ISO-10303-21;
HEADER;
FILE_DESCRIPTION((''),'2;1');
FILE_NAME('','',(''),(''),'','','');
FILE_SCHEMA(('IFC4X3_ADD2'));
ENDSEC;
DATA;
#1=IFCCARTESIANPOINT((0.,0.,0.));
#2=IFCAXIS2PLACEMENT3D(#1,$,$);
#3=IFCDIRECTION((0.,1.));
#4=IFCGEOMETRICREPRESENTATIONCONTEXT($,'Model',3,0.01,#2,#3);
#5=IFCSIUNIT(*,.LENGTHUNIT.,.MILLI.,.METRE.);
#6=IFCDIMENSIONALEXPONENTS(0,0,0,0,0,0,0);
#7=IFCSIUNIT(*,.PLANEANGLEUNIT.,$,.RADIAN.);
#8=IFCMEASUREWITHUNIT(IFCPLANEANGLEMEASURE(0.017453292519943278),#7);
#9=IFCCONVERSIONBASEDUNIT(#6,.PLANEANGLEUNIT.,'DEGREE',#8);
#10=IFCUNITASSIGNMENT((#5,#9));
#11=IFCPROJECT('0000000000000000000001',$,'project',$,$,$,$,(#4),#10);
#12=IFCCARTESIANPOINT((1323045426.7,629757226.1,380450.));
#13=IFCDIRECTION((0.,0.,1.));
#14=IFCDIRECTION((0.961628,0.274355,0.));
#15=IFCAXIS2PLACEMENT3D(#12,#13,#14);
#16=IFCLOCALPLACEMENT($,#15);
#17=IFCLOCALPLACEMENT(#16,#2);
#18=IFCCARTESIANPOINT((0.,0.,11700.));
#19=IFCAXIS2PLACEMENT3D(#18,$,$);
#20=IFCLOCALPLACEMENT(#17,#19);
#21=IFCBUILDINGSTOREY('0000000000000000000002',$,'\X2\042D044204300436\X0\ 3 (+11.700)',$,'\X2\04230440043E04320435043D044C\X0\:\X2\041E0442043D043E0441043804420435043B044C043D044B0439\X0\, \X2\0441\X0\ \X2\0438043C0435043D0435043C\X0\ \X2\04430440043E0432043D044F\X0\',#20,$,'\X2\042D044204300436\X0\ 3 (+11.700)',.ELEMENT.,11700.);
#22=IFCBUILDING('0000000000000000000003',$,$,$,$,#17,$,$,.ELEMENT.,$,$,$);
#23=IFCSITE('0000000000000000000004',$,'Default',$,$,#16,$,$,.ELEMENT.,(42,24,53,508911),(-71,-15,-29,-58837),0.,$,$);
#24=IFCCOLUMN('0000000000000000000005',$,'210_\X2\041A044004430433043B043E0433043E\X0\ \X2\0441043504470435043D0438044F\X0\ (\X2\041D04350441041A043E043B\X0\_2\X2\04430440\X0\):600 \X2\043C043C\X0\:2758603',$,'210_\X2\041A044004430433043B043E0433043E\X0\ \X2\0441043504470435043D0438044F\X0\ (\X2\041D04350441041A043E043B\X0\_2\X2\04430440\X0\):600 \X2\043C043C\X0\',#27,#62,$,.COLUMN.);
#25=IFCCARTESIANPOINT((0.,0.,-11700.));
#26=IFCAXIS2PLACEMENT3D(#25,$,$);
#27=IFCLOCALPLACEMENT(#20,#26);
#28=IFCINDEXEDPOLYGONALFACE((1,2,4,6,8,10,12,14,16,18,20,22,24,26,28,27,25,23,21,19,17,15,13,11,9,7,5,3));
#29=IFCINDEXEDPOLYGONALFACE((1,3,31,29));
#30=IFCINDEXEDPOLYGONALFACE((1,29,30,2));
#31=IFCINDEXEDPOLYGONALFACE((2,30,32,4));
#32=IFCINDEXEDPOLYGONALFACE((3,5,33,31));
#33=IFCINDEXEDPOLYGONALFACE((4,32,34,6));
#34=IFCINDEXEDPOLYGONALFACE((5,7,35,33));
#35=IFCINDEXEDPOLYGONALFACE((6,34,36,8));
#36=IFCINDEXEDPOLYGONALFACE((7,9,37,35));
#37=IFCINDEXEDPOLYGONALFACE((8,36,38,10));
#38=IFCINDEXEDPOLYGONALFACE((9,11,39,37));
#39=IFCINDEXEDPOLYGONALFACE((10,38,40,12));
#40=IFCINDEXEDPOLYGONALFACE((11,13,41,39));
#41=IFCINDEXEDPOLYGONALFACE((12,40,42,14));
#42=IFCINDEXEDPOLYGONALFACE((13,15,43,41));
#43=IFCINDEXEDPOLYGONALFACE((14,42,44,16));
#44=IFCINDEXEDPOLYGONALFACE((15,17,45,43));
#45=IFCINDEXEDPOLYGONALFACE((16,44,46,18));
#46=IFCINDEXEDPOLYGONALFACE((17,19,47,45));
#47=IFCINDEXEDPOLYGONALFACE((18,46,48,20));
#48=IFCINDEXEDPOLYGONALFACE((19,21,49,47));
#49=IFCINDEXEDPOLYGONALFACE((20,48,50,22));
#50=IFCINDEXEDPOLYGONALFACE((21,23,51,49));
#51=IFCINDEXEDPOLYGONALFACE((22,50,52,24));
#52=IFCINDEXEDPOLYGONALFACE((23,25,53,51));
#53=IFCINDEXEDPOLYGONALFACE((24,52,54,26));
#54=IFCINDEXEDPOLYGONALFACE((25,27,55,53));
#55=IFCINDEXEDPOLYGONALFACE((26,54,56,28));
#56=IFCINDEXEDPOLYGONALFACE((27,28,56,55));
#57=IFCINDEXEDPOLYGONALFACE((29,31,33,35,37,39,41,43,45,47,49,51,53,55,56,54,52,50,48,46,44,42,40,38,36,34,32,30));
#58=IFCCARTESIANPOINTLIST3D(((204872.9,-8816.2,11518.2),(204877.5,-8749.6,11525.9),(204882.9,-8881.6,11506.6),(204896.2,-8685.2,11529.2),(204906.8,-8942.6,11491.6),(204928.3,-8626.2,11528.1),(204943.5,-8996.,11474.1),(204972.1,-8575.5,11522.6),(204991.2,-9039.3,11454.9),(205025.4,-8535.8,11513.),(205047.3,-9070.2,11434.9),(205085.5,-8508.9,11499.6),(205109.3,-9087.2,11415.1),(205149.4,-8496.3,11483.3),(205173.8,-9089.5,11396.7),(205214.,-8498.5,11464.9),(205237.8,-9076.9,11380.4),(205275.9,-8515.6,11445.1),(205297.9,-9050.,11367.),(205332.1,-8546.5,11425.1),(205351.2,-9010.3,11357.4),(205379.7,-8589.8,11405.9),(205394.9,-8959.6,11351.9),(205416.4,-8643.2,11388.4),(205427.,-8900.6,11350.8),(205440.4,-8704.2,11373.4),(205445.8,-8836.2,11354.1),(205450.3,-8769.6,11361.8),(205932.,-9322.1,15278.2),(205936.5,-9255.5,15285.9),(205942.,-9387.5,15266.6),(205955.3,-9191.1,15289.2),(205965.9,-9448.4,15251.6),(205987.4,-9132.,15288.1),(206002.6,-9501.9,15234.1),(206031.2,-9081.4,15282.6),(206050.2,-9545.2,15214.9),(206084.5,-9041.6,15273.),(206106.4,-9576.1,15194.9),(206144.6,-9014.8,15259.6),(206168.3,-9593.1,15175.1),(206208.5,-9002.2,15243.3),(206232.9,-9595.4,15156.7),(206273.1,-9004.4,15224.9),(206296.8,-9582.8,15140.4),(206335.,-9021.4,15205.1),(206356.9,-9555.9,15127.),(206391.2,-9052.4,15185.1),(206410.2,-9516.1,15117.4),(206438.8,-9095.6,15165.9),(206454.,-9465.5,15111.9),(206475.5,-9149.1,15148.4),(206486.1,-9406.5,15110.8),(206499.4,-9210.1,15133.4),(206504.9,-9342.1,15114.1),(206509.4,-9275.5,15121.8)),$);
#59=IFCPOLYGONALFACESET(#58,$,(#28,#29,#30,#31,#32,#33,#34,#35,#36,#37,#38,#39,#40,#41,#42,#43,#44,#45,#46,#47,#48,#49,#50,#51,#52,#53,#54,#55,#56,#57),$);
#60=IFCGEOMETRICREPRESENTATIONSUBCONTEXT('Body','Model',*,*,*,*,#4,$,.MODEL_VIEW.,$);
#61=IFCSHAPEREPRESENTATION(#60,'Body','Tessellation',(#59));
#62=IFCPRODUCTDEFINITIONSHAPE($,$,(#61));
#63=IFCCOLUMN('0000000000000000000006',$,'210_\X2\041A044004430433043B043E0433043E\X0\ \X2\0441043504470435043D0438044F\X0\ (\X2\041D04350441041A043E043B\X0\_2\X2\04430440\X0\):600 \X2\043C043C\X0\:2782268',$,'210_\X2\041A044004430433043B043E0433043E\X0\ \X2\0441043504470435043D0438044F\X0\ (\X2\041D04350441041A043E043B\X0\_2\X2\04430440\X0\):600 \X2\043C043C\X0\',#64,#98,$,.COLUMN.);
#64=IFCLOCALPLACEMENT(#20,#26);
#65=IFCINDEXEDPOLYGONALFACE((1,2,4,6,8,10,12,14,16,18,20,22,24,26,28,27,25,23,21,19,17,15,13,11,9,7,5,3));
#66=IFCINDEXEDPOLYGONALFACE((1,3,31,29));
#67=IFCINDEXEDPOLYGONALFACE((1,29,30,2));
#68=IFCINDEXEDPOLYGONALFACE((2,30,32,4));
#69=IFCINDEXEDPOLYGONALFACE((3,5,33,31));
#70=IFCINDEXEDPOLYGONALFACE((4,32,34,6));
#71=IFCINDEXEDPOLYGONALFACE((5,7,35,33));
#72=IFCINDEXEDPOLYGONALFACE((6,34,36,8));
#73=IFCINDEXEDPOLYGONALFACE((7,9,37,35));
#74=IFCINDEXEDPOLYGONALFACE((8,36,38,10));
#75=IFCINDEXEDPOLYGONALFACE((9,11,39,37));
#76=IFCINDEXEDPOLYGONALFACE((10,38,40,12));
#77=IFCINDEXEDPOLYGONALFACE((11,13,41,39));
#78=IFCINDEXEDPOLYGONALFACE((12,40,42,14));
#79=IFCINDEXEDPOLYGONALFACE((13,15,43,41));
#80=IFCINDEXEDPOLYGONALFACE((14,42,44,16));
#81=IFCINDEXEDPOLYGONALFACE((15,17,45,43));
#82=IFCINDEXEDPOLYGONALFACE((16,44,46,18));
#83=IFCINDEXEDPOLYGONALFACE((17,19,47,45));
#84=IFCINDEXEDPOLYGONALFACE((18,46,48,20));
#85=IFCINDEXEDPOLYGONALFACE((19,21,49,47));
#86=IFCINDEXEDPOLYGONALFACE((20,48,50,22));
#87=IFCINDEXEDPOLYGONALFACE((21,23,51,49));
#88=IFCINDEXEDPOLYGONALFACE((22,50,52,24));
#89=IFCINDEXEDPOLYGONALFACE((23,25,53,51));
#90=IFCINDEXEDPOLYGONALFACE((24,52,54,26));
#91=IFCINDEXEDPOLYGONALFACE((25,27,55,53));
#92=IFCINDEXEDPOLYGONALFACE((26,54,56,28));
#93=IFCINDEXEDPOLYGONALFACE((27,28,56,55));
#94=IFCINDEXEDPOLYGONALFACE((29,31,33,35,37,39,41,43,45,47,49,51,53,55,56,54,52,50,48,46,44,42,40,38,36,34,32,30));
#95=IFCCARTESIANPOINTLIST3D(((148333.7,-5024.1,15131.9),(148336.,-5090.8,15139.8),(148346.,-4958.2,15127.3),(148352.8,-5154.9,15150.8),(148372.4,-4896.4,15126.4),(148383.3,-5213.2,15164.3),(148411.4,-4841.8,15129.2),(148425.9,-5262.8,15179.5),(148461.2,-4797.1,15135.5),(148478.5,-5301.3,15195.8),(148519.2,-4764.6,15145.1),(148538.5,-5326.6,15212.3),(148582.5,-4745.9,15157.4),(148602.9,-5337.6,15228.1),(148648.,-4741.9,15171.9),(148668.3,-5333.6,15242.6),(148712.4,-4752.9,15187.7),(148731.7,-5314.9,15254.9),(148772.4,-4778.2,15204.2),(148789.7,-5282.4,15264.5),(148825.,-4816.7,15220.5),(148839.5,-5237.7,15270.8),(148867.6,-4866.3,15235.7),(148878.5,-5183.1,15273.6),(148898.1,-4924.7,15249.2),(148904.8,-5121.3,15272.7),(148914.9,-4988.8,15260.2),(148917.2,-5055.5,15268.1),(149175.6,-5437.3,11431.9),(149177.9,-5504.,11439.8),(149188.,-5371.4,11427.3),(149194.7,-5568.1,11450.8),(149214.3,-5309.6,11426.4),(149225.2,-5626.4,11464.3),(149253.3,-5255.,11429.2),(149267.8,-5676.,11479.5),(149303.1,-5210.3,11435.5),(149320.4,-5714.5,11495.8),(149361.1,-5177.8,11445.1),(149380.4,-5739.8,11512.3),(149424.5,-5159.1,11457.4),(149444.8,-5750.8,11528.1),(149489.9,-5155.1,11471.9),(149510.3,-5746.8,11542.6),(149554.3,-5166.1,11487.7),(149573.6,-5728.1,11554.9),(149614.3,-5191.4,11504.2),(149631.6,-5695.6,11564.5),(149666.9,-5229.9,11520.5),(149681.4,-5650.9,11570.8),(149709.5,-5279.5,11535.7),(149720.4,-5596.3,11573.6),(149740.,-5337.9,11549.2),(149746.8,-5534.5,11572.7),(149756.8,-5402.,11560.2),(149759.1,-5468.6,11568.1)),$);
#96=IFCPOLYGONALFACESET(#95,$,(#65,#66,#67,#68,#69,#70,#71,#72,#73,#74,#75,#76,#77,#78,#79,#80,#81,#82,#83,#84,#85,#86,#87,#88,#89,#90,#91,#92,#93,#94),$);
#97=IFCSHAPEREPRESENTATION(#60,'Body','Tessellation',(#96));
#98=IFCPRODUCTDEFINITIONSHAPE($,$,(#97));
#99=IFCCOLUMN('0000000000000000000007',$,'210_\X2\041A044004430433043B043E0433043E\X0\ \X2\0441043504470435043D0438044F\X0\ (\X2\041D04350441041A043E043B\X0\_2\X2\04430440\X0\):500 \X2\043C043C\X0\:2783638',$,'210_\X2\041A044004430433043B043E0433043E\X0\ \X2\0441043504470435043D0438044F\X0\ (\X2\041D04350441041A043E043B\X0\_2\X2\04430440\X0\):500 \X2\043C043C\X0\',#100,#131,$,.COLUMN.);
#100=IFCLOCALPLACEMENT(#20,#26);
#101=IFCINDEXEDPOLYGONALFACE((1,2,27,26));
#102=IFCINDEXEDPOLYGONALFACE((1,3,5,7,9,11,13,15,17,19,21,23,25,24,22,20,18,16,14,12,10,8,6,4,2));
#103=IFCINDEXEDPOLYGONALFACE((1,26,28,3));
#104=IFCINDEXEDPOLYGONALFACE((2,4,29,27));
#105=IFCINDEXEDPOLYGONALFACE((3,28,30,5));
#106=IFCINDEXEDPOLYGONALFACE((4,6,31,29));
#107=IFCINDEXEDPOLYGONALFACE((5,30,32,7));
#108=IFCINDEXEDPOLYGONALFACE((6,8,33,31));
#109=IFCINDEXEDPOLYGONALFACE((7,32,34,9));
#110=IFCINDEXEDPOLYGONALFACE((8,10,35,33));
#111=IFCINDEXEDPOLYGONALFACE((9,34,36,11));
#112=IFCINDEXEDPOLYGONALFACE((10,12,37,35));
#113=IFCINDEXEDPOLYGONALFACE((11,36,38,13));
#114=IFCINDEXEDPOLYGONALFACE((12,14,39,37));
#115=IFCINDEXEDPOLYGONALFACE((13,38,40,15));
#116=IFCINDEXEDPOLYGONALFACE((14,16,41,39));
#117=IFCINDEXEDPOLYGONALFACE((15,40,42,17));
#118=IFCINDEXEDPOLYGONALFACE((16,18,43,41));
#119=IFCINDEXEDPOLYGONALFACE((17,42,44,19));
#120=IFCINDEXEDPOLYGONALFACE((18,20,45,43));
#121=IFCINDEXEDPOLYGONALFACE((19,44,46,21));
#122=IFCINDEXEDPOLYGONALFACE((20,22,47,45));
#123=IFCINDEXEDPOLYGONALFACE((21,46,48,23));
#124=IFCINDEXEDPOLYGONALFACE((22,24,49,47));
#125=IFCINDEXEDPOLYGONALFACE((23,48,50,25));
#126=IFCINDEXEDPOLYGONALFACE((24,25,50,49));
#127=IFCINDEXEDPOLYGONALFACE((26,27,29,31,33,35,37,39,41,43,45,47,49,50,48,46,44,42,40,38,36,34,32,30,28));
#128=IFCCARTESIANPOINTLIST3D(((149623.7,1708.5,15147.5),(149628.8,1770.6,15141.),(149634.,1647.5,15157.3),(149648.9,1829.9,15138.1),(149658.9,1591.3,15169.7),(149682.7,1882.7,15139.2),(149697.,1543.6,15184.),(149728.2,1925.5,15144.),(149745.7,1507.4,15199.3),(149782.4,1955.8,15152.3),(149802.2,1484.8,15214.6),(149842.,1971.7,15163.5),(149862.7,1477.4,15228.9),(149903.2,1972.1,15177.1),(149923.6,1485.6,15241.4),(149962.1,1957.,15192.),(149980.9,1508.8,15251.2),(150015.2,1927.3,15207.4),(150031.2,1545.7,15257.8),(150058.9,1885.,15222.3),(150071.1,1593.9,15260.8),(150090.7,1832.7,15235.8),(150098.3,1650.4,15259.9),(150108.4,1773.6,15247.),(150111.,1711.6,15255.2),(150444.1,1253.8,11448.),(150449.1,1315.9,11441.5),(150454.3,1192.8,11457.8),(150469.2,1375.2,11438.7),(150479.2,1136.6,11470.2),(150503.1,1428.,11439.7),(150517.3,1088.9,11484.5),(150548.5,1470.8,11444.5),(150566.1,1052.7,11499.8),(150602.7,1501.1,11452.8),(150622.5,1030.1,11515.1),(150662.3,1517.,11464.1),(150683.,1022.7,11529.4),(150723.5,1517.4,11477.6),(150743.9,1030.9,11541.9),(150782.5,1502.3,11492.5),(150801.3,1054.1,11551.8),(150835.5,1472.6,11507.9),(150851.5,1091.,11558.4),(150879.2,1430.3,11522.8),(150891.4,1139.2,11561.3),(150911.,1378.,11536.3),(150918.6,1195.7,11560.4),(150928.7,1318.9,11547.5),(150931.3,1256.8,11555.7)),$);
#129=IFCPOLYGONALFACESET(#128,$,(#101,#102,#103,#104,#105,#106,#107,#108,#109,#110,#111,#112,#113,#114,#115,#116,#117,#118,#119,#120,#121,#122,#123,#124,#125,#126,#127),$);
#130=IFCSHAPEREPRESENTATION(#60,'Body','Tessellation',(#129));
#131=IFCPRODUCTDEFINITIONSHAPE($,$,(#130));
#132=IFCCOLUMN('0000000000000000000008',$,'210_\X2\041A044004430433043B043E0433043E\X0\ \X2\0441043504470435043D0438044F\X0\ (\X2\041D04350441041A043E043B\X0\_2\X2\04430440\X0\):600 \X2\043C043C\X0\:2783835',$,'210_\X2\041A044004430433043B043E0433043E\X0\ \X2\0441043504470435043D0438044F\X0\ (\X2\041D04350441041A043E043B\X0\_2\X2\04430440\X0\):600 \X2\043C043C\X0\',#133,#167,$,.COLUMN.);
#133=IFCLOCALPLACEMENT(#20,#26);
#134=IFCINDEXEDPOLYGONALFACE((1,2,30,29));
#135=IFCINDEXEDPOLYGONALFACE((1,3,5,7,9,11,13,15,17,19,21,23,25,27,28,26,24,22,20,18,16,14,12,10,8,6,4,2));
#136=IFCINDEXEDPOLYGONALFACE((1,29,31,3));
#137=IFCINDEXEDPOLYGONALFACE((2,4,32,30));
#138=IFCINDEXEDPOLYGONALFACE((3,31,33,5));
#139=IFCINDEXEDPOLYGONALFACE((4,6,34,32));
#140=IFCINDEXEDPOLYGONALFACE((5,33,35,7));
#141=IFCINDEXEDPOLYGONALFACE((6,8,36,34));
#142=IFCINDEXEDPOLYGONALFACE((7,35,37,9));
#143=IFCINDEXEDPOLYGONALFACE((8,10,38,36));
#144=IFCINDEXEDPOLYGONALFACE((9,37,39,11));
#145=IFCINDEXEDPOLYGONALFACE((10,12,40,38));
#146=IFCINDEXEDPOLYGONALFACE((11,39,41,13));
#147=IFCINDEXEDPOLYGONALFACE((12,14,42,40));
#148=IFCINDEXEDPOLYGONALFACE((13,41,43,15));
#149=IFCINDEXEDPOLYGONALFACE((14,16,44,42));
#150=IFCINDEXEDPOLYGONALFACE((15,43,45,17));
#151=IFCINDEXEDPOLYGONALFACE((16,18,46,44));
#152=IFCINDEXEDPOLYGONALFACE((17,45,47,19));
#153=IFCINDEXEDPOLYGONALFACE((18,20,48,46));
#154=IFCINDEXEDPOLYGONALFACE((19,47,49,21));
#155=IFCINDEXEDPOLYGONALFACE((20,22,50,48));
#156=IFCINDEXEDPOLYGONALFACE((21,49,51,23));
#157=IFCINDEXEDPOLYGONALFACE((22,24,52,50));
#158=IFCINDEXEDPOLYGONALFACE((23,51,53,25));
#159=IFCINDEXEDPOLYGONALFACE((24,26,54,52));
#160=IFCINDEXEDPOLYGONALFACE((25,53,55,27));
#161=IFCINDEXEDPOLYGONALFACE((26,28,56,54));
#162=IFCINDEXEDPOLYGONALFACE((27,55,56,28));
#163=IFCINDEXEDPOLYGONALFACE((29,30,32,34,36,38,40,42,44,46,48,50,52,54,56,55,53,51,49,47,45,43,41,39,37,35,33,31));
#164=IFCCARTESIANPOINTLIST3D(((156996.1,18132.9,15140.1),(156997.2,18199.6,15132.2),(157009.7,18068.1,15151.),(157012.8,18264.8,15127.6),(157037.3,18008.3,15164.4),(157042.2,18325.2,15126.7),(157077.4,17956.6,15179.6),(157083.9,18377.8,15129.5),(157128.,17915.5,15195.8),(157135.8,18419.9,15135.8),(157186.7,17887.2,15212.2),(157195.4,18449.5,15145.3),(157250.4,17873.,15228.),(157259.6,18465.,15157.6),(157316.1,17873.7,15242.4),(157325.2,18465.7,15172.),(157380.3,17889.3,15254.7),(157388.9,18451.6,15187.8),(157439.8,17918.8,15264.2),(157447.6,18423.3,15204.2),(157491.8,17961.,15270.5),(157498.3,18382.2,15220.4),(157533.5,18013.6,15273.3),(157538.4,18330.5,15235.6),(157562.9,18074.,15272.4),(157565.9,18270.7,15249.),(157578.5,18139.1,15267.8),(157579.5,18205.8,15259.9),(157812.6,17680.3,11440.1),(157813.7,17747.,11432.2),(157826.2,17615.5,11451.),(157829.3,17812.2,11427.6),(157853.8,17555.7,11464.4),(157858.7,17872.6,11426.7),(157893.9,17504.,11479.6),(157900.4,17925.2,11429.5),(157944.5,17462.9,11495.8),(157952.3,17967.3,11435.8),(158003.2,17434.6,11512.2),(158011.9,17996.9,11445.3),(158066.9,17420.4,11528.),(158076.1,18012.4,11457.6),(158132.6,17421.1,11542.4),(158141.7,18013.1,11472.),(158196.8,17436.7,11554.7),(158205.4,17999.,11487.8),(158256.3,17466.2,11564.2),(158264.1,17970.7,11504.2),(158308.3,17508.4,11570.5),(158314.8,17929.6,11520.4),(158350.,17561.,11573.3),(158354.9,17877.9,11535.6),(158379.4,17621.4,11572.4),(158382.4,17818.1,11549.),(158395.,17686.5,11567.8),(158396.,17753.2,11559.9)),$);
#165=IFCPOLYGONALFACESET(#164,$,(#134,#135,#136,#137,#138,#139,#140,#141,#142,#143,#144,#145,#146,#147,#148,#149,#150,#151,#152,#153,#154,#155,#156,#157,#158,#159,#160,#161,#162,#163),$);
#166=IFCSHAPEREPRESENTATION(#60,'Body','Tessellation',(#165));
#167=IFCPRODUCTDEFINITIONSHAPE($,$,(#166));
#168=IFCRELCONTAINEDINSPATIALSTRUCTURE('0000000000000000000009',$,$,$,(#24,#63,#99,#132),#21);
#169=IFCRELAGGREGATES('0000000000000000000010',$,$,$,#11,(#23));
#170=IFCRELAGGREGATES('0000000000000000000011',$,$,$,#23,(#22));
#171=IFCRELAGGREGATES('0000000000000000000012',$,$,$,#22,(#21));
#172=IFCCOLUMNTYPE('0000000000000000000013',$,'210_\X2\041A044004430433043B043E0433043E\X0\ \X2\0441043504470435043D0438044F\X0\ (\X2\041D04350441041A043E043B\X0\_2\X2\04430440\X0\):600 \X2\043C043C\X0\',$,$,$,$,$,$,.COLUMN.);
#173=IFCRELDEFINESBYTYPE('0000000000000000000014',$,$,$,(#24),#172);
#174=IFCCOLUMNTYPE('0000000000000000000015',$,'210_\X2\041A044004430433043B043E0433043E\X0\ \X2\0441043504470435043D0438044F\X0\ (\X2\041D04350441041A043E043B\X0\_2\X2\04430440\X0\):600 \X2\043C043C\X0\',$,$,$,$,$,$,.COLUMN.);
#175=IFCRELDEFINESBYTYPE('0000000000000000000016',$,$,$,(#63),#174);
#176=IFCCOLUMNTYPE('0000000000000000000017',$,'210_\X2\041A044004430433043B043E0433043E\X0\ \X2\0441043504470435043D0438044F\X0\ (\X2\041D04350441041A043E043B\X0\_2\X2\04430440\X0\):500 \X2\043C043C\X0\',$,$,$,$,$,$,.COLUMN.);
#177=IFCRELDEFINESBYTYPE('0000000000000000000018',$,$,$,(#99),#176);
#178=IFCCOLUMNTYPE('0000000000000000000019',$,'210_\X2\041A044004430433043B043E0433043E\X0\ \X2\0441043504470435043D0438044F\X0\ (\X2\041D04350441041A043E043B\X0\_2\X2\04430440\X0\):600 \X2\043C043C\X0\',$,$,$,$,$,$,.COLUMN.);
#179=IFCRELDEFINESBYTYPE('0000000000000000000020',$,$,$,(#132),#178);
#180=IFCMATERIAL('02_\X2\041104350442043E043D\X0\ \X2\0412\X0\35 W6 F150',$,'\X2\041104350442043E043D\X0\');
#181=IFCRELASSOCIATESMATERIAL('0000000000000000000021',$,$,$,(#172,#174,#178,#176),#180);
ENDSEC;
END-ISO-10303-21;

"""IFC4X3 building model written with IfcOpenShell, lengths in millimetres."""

from ifc_helpers import new_model, entity, si_unit, converted_unit, direction, frame, frame_2d, origin, origin_2d_with_axis, place, context, subcontext, project, spatial, circle, extrude, source, transform, mapped, material, material_profile, profile_set, type_object, type_shapes, element, save


model = new_model("IFC4X3")

# Units and contexts
model_context = context("Model", 3, precision=0.01, world=origin(), true_north=direction((0.0, 1.0)))
body_context = subcontext(model_context, "Body", "Model", "MODEL_VIEW")
ifc_project = project(units=[si_unit("LENGTHUNIT", "METRE", prefix="MILLI"), converted_unit("PLANEANGLEUNIT", "DEGREE", entity("IfcPlaneAngleMeasure", 0.017453292519943278), si_unit("PLANEANGLEUNIT", "RADIAN"), dimensions=[0, 0, 0, 0, 0, 0, 0])], contexts=[model_context])

# Site, building, storey
site_placement = place(None, frame((1323045426.7, 629757226.1, 380450.0), z_axis=(0.0, 0.0, 1.0), x_axis=(0.961628, 0.274355, 0.0)))
site = spatial("IfcSite", under=ifc_project, at=site_placement, Name="Default", CompositionType="ELEMENT", RefLatitude=(42, 24, 53, 508911), RefLongitude=(-71, -15, -29, -58837), RefElevation=0.0)
building_placement = place(site_placement, origin())
building = spatial("IfcBuilding", under=site, at=building_placement, CompositionType="ELEMENT")
storey_placement = place(building_placement, frame((0.0, 0.0, 11700.0)))
storey = spatial("IfcBuildingStorey", under=building, at=storey_placement, Name="Этаж 3 (+11.700)", ObjectType="Уровень:Относительный, с именем уровня", LongName="Этаж 3 (+11.700)", CompositionType="ELEMENT", Elevation=11700.0)

# Columns
ifc_material_1 = material(Name="02_Бетон В35 W6 F150", Category="Бетон")
ifc_material_profile_1 = material_profile(ifc_material_1, circle(Radius=300.0, at=origin_2d_with_axis()), Name="600 мм")
ifc_profile_set_1 = profile_set([ifc_material_profile_1], Name="600 мм")
column_type_1 = type_object("IfcColumnType", Name="210_Круглого сечения (НесКол_2ур):600 мм", PredefinedType="COLUMN", material=ifc_profile_set_1)
shared_shape_1 = source(origin(), body_context, "Body", "SweptSolid", [
    extrude(circle(Radius=300.0, at=origin_2d_with_axis()), frame((205161.6, -8792.9, 11440.0), z_axis=(0.268873, -0.12843, 0.954575), x_axis=(0.040619, -0.988677, -0.144459)), (0.0, 0.0, 1.0), 3938.9),
])
type_shapes(column_type_1, [shared_shape_1])
column_1_placement = place(storey_placement, frame((0.0, 0.0, -11700.0)))
element("IfcColumn", 1, at=column_1_placement, inside=storey, type_object=column_type_1, Name="210_Круглого сечения (НесКол_2ур):600 мм:2758603", ObjectType="210_Круглого сечения (НесКол_2ур):600 мм", PredefinedType="COLUMN", context=body_context, shape_type="MappedRepresentation", body=[
    mapped(shared_shape_1, transform((0.0, 0.0, 0.0), scale=1.0)),
])
column_type_2 = type_object("IfcColumnType", Name="210_Круглого сечения (НесКол_2ур):600 мм", PredefinedType="COLUMN", material=ifc_profile_set_1)
shared_shape_2 = source(origin(), body_context, "Body", "SweptSolid", [
    extrude(circle(Radius=300.0, at=frame_2d((0.0, 0.0), x_axis=(1.0, 0.0))), frame((149467.4, -5453.0, 11500.0), z_axis=(-0.220572, 0.108251, 0.969345), x_axis=(-0.807217, -0.578111, -0.11912)), (0.0, 0.0, 1.0), 3817.0),
])
type_shapes(column_type_2, [shared_shape_2])
column_2_placement = place(storey_placement, frame((0.0, 0.0, -11700.0)))
element("IfcColumn", 2, at=column_2_placement, inside=storey, type_object=column_type_2, Name="210_Круглого сечения (НесКол_2ур):600 мм:2782268", ObjectType="210_Круглого сечения (НесКол_2ур):600 мм", PredefinedType="COLUMN", context=body_context, shape_type="MappedRepresentation", body=[
    mapped(shared_shape_2, transform((0.0, 0.0, 0.0), scale=1.0)),
])
ifc_material_profile_2 = material_profile(ifc_material_1, circle(Radius=250.0, at=origin_2d_with_axis()), Name="500 мм")
ifc_profile_set_2 = profile_set([ifc_material_profile_2], Name="500 мм")
column_type_3 = type_object("IfcColumnType", Name="210_Круглого сечения (НесКол_2ур):500 мм", PredefinedType="COLUMN", material=ifc_profile_set_2)
shared_shape_3 = source(origin(), body_context, "Body", "SweptSolid", [
    extrude(circle(Radius=250.0, at=frame_2d((0.0, 0.0), x_axis=(1.0, 0.0))), frame((150688.0, 1270.9, 11500.0), z_axis=(-0.21494, 0.119143, 0.969333), x_axis=(-0.835044, -0.537127, -0.119143)), (0.0, 0.0, 1.0), 3816.5),
])
type_shapes(column_type_3, [shared_shape_3])
column_3_placement = place(storey_placement, frame((0.0, 0.0, -11700.0)))
element("IfcColumn", 3, at=column_3_placement, inside=storey, type_object=column_type_3, Name="210_Круглого сечения (НесКол_2ур):500 мм:2783638", ObjectType="210_Круглого сечения (НесКол_2ур):500 мм", PredefinedType="COLUMN", context=body_context, shape_type="MappedRepresentation", body=[
    mapped(shared_shape_3, transform((0.0, 0.0, 0.0), scale=1.0)),
])
column_type_4 = type_object("IfcColumnType", Name="210_Круглого сечения (НесКол_2ур):600 мм", PredefinedType="COLUMN", material=ifc_profile_set_1)
shared_shape_4 = source(origin(), body_context, "Body", "SweptSolid", [
    extrude(circle(Radius=300.0, at=frame_2d((0.0, 0.0), x_axis=(1.0, 0.0))), frame((158104.3, 17716.8, 11500.0), z_axis=(-0.213968, 0.118605, 0.969614), x_axis=(-0.835164, -0.537061, -0.118605)), (0.0, 0.0, 1.0), 3816.0),
])
type_shapes(column_type_4, [shared_shape_4])
column_4_placement = place(storey_placement, frame((0.0, 0.0, -11700.0)))
element("IfcColumn", 4, at=column_4_placement, inside=storey, type_object=column_type_4, Name="210_Круглого сечения (НесКол_2ур):600 мм:2783835", ObjectType="210_Круглого сечения (НесКол_2ур):600 мм", PredefinedType="COLUMN", context=body_context, shape_type="MappedRepresentation", body=[
    mapped(shared_shape_4, transform((0.0, 0.0, 0.0), scale=1.0)),
])

save(model, "model.ifc")
